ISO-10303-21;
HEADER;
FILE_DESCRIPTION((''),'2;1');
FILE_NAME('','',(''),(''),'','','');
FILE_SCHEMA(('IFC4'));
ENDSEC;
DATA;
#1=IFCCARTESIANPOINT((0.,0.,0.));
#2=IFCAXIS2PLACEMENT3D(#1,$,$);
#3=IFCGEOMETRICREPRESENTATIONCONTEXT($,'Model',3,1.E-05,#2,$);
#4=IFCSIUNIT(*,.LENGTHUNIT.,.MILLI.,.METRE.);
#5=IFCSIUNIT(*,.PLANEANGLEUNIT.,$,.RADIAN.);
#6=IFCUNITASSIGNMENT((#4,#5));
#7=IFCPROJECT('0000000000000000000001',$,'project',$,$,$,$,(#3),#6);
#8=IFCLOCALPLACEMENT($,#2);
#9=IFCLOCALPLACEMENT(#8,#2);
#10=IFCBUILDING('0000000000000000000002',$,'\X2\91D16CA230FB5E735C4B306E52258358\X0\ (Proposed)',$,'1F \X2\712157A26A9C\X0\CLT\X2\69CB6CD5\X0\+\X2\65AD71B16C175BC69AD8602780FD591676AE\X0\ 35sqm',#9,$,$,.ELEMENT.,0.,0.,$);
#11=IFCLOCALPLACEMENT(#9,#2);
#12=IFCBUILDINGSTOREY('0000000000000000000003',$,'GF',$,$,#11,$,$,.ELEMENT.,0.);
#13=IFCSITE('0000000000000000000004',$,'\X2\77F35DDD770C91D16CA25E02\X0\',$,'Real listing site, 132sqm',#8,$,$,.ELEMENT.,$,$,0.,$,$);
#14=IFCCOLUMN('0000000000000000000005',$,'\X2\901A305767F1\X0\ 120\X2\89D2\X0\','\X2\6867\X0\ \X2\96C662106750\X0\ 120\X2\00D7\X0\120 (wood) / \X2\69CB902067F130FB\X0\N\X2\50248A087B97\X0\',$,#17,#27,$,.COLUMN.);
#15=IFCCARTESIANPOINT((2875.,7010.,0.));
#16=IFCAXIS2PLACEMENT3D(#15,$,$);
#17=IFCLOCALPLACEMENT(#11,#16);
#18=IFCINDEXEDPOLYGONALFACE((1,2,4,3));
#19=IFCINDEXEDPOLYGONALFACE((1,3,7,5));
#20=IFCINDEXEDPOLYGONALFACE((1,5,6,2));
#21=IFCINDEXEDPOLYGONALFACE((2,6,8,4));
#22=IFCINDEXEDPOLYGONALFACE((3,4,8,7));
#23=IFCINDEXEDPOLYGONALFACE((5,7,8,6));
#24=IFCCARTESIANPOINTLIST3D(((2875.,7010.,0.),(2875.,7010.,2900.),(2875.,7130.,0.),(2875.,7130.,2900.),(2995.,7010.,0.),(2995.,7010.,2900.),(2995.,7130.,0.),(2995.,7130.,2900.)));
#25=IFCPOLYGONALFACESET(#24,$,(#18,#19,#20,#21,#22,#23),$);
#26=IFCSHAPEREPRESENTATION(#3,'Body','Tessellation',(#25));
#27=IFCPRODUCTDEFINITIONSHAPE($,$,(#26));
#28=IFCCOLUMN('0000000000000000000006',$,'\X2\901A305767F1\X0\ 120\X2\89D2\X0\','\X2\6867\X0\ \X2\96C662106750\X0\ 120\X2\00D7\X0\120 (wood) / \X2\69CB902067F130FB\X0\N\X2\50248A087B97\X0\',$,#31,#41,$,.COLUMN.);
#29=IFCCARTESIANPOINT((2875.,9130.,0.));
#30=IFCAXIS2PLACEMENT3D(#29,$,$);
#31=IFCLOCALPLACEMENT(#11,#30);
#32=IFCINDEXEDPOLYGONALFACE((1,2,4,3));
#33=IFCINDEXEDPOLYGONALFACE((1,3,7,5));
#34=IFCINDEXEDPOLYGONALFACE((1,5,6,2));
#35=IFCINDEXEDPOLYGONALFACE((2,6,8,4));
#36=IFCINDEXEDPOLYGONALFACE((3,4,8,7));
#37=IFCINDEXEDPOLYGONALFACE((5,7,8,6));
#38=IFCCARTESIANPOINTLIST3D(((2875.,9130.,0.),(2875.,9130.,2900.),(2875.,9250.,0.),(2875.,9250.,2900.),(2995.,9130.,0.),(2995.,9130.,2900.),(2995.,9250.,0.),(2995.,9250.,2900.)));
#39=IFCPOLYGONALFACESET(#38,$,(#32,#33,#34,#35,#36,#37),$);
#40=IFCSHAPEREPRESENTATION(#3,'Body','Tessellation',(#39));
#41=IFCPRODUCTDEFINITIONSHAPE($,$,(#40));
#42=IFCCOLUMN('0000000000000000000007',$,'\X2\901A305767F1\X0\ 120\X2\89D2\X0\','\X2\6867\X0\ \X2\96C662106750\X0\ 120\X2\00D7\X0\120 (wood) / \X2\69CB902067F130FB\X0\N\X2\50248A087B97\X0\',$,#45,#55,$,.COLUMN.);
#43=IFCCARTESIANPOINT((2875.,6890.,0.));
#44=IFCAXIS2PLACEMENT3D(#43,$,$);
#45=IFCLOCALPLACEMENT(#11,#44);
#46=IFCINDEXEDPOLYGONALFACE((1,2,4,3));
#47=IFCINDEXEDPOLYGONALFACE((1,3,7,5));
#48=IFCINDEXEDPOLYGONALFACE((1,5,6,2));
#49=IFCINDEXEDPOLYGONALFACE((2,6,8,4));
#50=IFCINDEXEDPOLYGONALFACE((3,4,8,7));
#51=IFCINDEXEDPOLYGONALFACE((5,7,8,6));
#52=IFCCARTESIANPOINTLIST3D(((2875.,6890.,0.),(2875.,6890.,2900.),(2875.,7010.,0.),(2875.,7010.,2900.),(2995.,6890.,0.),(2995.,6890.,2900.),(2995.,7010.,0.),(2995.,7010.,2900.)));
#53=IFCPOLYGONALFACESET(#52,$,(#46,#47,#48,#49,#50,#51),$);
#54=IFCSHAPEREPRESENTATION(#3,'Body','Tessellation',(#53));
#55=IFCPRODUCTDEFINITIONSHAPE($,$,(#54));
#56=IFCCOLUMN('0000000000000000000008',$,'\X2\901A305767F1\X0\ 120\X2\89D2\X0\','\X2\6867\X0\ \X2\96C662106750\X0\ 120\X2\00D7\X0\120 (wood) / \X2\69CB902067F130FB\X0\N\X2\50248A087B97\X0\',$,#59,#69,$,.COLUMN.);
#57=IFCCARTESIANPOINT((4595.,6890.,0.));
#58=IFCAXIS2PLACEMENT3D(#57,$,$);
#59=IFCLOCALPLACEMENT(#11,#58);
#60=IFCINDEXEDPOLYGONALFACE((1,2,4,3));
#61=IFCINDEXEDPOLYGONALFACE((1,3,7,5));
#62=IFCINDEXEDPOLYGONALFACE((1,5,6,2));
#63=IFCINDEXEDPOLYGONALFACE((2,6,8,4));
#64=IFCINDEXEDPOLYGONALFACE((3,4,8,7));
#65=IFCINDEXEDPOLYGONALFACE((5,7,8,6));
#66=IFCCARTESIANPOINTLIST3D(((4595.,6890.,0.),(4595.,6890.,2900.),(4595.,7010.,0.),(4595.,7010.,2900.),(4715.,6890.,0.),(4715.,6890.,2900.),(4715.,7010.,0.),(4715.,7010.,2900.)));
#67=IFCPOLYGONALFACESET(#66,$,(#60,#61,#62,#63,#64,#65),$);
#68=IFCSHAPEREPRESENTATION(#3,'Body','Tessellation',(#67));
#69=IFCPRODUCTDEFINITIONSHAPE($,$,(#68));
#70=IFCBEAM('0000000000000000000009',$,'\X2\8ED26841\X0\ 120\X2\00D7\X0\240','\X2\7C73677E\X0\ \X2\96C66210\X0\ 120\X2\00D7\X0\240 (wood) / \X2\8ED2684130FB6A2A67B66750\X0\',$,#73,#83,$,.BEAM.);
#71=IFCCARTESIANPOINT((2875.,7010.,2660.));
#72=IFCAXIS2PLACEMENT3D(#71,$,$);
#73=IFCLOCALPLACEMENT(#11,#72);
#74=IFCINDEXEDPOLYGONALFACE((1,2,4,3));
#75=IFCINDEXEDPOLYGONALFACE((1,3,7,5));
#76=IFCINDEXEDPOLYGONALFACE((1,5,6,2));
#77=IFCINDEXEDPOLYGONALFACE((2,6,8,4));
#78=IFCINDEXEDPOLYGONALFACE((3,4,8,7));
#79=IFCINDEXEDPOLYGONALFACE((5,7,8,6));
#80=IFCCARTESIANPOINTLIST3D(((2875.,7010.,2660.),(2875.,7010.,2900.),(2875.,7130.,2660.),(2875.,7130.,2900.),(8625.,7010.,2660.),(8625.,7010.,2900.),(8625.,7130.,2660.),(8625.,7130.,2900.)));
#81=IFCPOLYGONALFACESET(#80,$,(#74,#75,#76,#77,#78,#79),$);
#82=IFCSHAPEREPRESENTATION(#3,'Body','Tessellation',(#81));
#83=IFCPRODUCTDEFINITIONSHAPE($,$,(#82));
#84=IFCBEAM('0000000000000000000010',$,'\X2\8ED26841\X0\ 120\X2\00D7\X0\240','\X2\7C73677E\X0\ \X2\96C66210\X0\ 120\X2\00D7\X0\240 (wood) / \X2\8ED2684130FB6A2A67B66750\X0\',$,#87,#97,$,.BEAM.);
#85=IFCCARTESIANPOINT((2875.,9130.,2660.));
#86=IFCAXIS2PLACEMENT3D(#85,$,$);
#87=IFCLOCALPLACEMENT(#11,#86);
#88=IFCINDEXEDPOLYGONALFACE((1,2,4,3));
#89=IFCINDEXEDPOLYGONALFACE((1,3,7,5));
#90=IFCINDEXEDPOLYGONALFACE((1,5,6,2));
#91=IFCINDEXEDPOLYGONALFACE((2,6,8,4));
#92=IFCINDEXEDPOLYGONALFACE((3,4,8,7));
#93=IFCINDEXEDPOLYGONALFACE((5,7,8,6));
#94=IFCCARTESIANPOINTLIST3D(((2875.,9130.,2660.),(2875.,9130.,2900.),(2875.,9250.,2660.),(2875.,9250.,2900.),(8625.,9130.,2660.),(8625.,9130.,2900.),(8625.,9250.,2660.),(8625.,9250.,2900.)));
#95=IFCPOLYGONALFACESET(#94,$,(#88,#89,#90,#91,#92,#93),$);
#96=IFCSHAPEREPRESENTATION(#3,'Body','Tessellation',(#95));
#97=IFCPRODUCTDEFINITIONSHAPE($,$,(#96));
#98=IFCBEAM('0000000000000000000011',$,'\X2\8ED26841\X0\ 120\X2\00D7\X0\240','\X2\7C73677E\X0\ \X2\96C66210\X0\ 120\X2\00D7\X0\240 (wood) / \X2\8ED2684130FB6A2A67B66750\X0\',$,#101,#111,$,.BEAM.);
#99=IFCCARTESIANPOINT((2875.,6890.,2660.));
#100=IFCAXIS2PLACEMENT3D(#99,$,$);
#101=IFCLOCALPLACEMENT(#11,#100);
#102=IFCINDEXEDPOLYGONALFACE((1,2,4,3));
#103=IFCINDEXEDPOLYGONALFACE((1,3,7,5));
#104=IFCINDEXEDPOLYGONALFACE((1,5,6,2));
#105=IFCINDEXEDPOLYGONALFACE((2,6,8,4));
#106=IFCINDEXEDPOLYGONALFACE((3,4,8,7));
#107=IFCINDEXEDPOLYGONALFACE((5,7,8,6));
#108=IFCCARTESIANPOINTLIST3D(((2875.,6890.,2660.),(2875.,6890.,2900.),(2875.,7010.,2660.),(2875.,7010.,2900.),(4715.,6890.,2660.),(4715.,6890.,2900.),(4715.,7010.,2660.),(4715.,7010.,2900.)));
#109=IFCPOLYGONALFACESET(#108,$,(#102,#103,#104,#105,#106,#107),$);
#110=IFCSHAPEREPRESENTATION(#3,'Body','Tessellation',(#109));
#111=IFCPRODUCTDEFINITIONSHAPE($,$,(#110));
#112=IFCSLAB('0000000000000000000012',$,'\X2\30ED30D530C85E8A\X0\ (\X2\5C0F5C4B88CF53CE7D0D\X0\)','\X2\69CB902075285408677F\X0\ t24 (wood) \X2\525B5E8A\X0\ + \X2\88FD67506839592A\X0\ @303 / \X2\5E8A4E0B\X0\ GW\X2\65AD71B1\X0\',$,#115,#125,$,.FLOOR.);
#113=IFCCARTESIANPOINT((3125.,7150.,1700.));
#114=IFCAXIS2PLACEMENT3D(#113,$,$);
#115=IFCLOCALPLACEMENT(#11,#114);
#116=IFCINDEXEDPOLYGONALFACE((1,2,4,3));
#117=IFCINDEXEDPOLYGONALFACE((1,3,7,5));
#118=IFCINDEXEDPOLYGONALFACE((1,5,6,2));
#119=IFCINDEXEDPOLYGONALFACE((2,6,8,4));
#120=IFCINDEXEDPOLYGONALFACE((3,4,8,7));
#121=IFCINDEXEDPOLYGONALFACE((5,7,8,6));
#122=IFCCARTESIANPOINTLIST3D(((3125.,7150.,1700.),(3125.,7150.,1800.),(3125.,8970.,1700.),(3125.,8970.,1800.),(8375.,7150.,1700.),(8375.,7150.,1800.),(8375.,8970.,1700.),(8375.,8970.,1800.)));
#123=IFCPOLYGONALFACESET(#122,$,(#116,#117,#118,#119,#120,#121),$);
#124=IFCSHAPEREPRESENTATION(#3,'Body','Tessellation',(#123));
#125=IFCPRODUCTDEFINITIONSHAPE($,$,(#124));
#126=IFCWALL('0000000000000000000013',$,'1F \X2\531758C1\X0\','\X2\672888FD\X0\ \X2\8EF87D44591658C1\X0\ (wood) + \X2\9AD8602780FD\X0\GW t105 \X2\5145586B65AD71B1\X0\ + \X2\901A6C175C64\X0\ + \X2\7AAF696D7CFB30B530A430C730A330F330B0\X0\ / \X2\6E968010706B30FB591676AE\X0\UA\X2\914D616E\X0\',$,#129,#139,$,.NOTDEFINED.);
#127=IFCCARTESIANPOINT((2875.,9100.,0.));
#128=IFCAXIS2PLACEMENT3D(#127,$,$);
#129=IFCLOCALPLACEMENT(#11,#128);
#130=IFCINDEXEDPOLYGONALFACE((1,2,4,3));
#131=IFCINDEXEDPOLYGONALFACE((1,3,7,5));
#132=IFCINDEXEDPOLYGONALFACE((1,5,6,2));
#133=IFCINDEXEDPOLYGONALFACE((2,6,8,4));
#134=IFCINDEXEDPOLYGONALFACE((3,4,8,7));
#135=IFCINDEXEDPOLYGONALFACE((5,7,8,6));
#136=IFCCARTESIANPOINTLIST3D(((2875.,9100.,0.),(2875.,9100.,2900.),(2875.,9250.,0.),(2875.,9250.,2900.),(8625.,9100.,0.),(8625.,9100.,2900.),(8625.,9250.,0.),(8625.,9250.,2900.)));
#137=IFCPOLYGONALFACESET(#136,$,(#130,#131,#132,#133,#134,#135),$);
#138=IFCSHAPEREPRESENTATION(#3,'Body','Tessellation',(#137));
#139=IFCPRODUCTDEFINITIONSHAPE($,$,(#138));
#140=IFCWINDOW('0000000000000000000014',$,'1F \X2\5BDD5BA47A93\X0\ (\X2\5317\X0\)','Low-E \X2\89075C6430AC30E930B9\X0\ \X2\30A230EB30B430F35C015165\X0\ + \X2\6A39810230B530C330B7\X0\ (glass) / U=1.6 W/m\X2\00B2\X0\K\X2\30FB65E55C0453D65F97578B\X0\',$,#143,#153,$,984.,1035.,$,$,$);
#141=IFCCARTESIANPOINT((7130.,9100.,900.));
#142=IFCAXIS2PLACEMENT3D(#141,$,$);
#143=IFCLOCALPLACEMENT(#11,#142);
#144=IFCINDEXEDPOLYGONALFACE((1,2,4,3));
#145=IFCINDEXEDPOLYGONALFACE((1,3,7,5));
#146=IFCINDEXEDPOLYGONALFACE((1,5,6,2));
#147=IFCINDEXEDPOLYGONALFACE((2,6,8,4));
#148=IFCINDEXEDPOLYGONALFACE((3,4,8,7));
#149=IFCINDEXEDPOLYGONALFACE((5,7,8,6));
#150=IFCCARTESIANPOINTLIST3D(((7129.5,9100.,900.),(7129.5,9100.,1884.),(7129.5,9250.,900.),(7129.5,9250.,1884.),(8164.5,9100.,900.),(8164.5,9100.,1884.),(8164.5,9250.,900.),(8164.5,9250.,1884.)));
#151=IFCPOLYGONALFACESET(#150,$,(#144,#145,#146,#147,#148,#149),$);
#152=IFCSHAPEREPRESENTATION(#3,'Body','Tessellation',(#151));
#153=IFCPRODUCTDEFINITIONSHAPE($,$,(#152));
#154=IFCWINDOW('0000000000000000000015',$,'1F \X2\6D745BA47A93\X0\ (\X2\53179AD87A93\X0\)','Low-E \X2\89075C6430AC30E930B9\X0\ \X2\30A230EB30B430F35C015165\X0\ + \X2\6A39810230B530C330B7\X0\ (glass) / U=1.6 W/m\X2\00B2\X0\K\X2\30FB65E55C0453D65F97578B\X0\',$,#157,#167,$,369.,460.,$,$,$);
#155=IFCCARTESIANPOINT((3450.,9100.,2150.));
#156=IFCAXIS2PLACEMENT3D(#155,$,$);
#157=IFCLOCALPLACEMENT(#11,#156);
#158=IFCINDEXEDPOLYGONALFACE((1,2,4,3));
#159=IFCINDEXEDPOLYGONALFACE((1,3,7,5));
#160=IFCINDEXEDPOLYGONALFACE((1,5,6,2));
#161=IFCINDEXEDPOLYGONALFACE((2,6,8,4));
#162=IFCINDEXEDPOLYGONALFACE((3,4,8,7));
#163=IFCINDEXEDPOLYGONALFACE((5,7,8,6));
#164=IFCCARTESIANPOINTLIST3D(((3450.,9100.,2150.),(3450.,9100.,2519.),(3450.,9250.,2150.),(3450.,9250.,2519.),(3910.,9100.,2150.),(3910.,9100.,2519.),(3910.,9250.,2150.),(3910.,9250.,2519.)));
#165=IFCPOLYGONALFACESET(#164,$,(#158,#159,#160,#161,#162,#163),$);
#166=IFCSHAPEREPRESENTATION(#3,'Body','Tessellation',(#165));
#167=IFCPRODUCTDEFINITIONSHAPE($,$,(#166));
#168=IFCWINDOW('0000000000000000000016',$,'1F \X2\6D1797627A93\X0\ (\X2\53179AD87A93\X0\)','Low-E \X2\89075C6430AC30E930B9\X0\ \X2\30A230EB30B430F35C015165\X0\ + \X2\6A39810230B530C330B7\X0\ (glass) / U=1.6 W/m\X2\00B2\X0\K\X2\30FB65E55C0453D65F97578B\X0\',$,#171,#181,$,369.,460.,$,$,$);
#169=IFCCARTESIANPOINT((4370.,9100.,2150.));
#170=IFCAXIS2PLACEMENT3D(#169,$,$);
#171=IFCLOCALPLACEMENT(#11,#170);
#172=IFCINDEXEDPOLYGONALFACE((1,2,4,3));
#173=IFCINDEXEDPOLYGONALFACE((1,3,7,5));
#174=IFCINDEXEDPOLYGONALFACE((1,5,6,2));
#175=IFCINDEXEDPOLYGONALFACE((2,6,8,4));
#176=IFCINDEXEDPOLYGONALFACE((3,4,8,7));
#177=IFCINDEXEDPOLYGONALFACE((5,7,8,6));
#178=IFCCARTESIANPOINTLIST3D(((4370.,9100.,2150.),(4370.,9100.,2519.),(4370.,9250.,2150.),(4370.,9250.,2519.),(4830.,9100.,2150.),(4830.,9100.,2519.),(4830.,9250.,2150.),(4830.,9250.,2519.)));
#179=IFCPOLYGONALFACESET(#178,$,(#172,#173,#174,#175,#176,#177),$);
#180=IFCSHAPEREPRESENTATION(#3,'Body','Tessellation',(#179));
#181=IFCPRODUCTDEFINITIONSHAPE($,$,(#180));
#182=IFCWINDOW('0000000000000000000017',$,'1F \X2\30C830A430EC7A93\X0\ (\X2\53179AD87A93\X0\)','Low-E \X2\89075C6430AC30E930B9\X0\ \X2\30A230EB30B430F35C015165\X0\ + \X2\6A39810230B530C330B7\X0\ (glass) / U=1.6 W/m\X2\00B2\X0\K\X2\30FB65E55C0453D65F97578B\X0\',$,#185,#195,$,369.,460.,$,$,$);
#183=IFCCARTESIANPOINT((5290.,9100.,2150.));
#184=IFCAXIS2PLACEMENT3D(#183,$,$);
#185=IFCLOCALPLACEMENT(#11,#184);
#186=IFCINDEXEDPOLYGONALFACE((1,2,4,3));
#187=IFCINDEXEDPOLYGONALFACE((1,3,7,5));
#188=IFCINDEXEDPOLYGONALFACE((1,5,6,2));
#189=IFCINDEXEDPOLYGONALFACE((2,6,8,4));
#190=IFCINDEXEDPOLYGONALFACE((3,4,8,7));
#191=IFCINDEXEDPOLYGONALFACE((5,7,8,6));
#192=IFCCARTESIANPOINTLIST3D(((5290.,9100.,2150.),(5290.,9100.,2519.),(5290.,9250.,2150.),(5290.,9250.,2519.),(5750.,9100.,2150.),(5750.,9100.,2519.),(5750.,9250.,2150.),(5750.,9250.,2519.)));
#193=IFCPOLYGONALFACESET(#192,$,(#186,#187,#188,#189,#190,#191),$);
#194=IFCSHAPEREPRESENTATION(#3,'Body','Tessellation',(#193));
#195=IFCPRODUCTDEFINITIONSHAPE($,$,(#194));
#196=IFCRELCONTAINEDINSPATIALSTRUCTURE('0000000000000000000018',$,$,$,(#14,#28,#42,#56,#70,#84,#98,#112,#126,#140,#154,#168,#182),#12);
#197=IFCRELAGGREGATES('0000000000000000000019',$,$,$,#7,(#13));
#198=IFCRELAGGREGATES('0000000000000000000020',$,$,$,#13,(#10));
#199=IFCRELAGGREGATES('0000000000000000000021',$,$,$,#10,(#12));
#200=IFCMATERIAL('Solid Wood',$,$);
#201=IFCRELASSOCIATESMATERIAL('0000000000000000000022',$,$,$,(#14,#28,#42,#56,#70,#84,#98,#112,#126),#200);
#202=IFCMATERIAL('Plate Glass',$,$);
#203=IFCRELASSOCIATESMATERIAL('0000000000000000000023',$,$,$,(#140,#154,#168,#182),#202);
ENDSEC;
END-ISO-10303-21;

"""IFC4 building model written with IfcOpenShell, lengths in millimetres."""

from ifc_helpers import new_model, si_unit, frame, frame_2d, origin, place, context, project, spatial, rectangle, extrude, material, element, fill, save


model = new_model("IFC4")

# Units and contexts
model_context = context("Model", 3, precision=1e-05, world=origin())
ifc_project = project(units=[si_unit("LENGTHUNIT", "METRE", prefix="MILLI"), si_unit("PLANEANGLEUNIT", "RADIAN")], contexts=[model_context])

# Site, building, storey
site_placement = place(None, origin())
site = spatial("IfcSite", under=ifc_project, at=site_placement, Name="石川県金沢市", ObjectType="Real listing site, 132sqm", CompositionType="ELEMENT", RefElevation=0.0)
building_placement = place(site_placement, origin())
building = spatial("IfcBuilding", under=site, at=building_placement, Name="金沢・平屋の別荘 (Proposed)", ObjectType="1F 無垢檜CLT構法+断熱気密高性能外皮 35sqm", CompositionType="ELEMENT", ElevationOfRefHeight=0.0, ElevationOfTerrain=0.0)
storey_placement = place(building_placement, origin())
storey = spatial("IfcBuildingStorey", under=building, at=storey_placement, Name="GF", CompositionType="ELEMENT", Elevation=0.0)

# Columns
ifc_material_1 = material(Name="Solid Wood")
column_1_placement = place(storey_placement, frame((2875.0, 7010.0, 0.0)))
element("IfcColumn", 1, at=column_1_placement, inside=storey, material=ifc_material_1, Name="通し柱 120角", Description="桧 集成材 120×120 (wood) / 構造柱・N値計算", PredefinedType="COLUMN", context=model_context, shape_type="SweptSolid", body=[
    extrude(rectangle(XDim=120.0, YDim=120.0, at=frame_2d((60.0, 60.0))), frame((2875.0, 7010.0, 0.0)), (0.0, 0.0, 1.0), 2900.0),
])
column_2_placement = place(storey_placement, frame((2875.0, 9130.0, 0.0)))
element("IfcColumn", 2, at=column_2_placement, inside=storey, material=ifc_material_1, Name="通し柱 120角", Description="桧 集成材 120×120 (wood) / 構造柱・N値計算", PredefinedType="COLUMN", context=model_context, shape_type="SweptSolid", body=[
    extrude(rectangle(XDim=120.0, YDim=120.0, at=frame_2d((60.0, 60.0))), frame((2875.0, 9130.0, 0.0)), (0.0, 0.0, 1.0), 2900.0),
])
column_3_placement = place(storey_placement, frame((2875.0, 6890.0, 0.0)))
element("IfcColumn", 3, at=column_3_placement, inside=storey, material=ifc_material_1, Name="通し柱 120角", Description="桧 集成材 120×120 (wood) / 構造柱・N値計算", PredefinedType="COLUMN", context=model_context, shape_type="SweptSolid", body=[
    extrude(rectangle(XDim=120.0, YDim=120.0, at=frame_2d((60.0, 60.0))), frame((2875.0, 6890.0, 0.0)), (0.0, 0.0, 1.0), 2900.0),
])
column_4_placement = place(storey_placement, frame((4595.0, 6890.0, 0.0)))
element("IfcColumn", 4, at=column_4_placement, inside=storey, material=ifc_material_1, Name="通し柱 120角", Description="桧 集成材 120×120 (wood) / 構造柱・N値計算", PredefinedType="COLUMN", context=model_context, shape_type="SweptSolid", body=[
    extrude(rectangle(XDim=120.0, YDim=120.0, at=frame_2d((60.0, 60.0))), frame((4595.0, 6890.0, 0.0)), (0.0, 0.0, 1.0), 2900.0),
])

# Beams
beam_1_placement = place(storey_placement, frame((2875.0, 7010.0, 2660.0)))
element("IfcBeam", 5, at=beam_1_placement, inside=storey, material=ifc_material_1, Name="軒桁 120×240", Description="米松 集成 120×240 (wood) / 軒桁・横架材", PredefinedType="BEAM", context=model_context, shape_type="SweptSolid", body=[
    extrude(rectangle(XDim=5750.0, YDim=120.0, at=frame_2d((2875.0, 60.0))), frame((2875.0, 7010.0, 2660.0)), (0.0, 0.0, 1.0), 240.0),
])
beam_2_placement = place(storey_placement, frame((2875.0, 9130.0, 2660.0)))
element("IfcBeam", 6, at=beam_2_placement, inside=storey, material=ifc_material_1, Name="軒桁 120×240", Description="米松 集成 120×240 (wood) / 軒桁・横架材", PredefinedType="BEAM", context=model_context, shape_type="SweptSolid", body=[
    extrude(rectangle(XDim=5750.0, YDim=120.0, at=frame_2d((2875.0, 60.0))), frame((2875.0, 9130.0, 2660.0)), (0.0, 0.0, 1.0), 240.0),
])
beam_3_placement = place(storey_placement, frame((2875.0, 6890.0, 2660.0)))
element("IfcBeam", 7, at=beam_3_placement, inside=storey, material=ifc_material_1, Name="軒桁 120×240", Description="米松 集成 120×240 (wood) / 軒桁・横架材", PredefinedType="BEAM", context=model_context, shape_type="SweptSolid", body=[
    extrude(rectangle(XDim=1840.0, YDim=120.0, at=frame_2d((920.0, 60.0))), frame((2875.0, 6890.0, 2660.0)), (0.0, 0.0, 1.0), 240.0),
])

# Slab
slab_1_placement = place(storey_placement, frame((3125.0, 7150.0, 1700.0)))
element("IfcSlab", 8, at=slab_1_placement, inside=storey, material=ifc_material_1, Name="ロフト床 (小屋裏収納)", Description="構造用合板 t24 (wood) 剛床 + 製材根太 @303 / 床下 GW断熱", PredefinedType="FLOOR", context=model_context, shape_type="SweptSolid", body=[
    extrude(rectangle(XDim=5250.0, YDim=1820.0, at=frame_2d((2625.0, 910.0))), frame((3125.0, 7150.0, 1700.0)), (0.0, 0.0, 1.0), 100.0),
])

# Wall, openings, windows
wall_1_placement = place(storey_placement, frame((2875.0, 9100.0, 0.0)))
wall_1 = element("IfcWall", 9, at=wall_1_placement, inside=storey, material=ifc_material_1, Name="1F 北壁", Description="木製 軸組外壁 (wood) + 高性能GW t105 充填断熱 + 通気層 + 窯業系サイディング / 準耐火・外皮UA配慮", PredefinedType="NOTDEFINED", context=model_context, shape_type="SweptSolid", body=[
    extrude(rectangle(XDim=5750.0, YDim=150.0, at=frame_2d((2875.0, 75.0))), frame((2875.0, 9100.0, 0.0)), (0.0, 0.0, 1.0), 2900.0),
])
opening_1_placement = place(storey_placement, frame((7130.0, 9100.0, 900.0)))
opening_1 = element("IfcOpeningElement", 10, at=opening_1_placement, cuts=wall_1, PredefinedType="NOTDEFINED", context=model_context, shape_type="SweptSolid", body=[
    extrude(rectangle(XDim=1035.0, YDim=150.0, at=frame_2d((517.0, 75.0))), frame((7130.0, 9100.0, 900.0)), (0.0, 0.0, 1.0), 984.0),
])
opening_2_placement = place(storey_placement, frame((3450.0, 9100.0, 2150.0)))
opening_2 = element("IfcOpeningElement", 11, at=opening_2_placement, cuts=wall_1, PredefinedType="NOTDEFINED", context=model_context, shape_type="SweptSolid", body=[
    extrude(rectangle(XDim=460.0, YDim=150.0, at=frame_2d((230.0, 75.0))), frame((3450.0, 9100.0, 2150.0)), (0.0, 0.0, 1.0), 369.0),
])
opening_3_placement = place(storey_placement, frame((4370.0, 9100.0, 2150.0)))
opening_3 = element("IfcOpeningElement", 12, at=opening_3_placement, cuts=wall_1, PredefinedType="NOTDEFINED", context=model_context, shape_type="SweptSolid", body=[
    extrude(rectangle(XDim=460.0, YDim=150.0, at=frame_2d((230.0, 75.0))), frame((4370.0, 9100.0, 2150.0)), (0.0, 0.0, 1.0), 369.0),
])
opening_4_placement = place(storey_placement, frame((5290.0, 9100.0, 2150.0)))
opening_4 = element("IfcOpeningElement", 13, at=opening_4_placement, cuts=wall_1, PredefinedType="NOTDEFINED", context=model_context, shape_type="SweptSolid", body=[
    extrude(rectangle(XDim=460.0, YDim=150.0, at=frame_2d((230.0, 75.0))), frame((5290.0, 9100.0, 2150.0)), (0.0, 0.0, 1.0), 369.0),
])
ifc_material_2 = material(Name="Plate Glass")
window_1_placement = place(storey_placement, frame((7130.0, 9100.0, 900.0)))
window_1 = element("IfcWindow", 14, at=window_1_placement, inside=storey, material=ifc_material_2, Name="1F 寝室窓 (北)", Description="Low-E 複層ガラス アルゴン封入 + 樹脂サッシ (glass) / U=1.6 W/m²K・日射取得型", OverallHeight=984.0, OverallWidth=1035.0, context=model_context, shape_type="SweptSolid", body=[
    extrude(rectangle(XDim=1035.0, YDim=150.0, at=frame_2d((517.0, 75.0))), frame((7130.0, 9100.0, 900.0)), (0.0, 0.0, 1.0), 984.0),
])
fill(opening_1, window_1)
window_2_placement = place(storey_placement, frame((3450.0, 9100.0, 2150.0)))
window_2 = element("IfcWindow", 15, at=window_2_placement, inside=storey, material=ifc_material_2, Name="1F 浴室窓 (北高窓)", Description="Low-E 複層ガラス アルゴン封入 + 樹脂サッシ (glass) / U=1.6 W/m²K・日射取得型", OverallHeight=369.0, OverallWidth=460.0, context=model_context, shape_type="SweptSolid", body=[
    extrude(rectangle(XDim=460.0, YDim=150.0, at=frame_2d((230.0, 75.0))), frame((3450.0, 9100.0, 2150.0)), (0.0, 0.0, 1.0), 369.0),
])
fill(opening_2, window_2)
window_3_placement = place(storey_placement, frame((4370.0, 9100.0, 2150.0)))
window_3 = element("IfcWindow", 16, at=window_3_placement, inside=storey, material=ifc_material_2, Name="1F 洗面窓 (北高窓)", Description="Low-E 複層ガラス アルゴン封入 + 樹脂サッシ (glass) / U=1.6 W/m²K・日射取得型", OverallHeight=369.0, OverallWidth=460.0, context=model_context, shape_type="SweptSolid", body=[
    extrude(rectangle(XDim=460.0, YDim=150.0, at=frame_2d((230.0, 75.0))), frame((4370.0, 9100.0, 2150.0)), (0.0, 0.0, 1.0), 369.0),
])
fill(opening_3, window_3)
window_4_placement = place(storey_placement, frame((5290.0, 9100.0, 2150.0)))
window_4 = element("IfcWindow", 17, at=window_4_placement, inside=storey, material=ifc_material_2, Name="1F トイレ窓 (北高窓)", Description="Low-E 複層ガラス アルゴン封入 + 樹脂サッシ (glass) / U=1.6 W/m²K・日射取得型", OverallHeight=369.0, OverallWidth=460.0, context=model_context, shape_type="SweptSolid", body=[
    extrude(rectangle(XDim=460.0, YDim=150.0, at=frame_2d((230.0, 75.0))), frame((5290.0, 9100.0, 2150.0)), (0.0, 0.0, 1.0), 369.0),
])
fill(opening_4, window_4)

save(model, "model.ifc")
